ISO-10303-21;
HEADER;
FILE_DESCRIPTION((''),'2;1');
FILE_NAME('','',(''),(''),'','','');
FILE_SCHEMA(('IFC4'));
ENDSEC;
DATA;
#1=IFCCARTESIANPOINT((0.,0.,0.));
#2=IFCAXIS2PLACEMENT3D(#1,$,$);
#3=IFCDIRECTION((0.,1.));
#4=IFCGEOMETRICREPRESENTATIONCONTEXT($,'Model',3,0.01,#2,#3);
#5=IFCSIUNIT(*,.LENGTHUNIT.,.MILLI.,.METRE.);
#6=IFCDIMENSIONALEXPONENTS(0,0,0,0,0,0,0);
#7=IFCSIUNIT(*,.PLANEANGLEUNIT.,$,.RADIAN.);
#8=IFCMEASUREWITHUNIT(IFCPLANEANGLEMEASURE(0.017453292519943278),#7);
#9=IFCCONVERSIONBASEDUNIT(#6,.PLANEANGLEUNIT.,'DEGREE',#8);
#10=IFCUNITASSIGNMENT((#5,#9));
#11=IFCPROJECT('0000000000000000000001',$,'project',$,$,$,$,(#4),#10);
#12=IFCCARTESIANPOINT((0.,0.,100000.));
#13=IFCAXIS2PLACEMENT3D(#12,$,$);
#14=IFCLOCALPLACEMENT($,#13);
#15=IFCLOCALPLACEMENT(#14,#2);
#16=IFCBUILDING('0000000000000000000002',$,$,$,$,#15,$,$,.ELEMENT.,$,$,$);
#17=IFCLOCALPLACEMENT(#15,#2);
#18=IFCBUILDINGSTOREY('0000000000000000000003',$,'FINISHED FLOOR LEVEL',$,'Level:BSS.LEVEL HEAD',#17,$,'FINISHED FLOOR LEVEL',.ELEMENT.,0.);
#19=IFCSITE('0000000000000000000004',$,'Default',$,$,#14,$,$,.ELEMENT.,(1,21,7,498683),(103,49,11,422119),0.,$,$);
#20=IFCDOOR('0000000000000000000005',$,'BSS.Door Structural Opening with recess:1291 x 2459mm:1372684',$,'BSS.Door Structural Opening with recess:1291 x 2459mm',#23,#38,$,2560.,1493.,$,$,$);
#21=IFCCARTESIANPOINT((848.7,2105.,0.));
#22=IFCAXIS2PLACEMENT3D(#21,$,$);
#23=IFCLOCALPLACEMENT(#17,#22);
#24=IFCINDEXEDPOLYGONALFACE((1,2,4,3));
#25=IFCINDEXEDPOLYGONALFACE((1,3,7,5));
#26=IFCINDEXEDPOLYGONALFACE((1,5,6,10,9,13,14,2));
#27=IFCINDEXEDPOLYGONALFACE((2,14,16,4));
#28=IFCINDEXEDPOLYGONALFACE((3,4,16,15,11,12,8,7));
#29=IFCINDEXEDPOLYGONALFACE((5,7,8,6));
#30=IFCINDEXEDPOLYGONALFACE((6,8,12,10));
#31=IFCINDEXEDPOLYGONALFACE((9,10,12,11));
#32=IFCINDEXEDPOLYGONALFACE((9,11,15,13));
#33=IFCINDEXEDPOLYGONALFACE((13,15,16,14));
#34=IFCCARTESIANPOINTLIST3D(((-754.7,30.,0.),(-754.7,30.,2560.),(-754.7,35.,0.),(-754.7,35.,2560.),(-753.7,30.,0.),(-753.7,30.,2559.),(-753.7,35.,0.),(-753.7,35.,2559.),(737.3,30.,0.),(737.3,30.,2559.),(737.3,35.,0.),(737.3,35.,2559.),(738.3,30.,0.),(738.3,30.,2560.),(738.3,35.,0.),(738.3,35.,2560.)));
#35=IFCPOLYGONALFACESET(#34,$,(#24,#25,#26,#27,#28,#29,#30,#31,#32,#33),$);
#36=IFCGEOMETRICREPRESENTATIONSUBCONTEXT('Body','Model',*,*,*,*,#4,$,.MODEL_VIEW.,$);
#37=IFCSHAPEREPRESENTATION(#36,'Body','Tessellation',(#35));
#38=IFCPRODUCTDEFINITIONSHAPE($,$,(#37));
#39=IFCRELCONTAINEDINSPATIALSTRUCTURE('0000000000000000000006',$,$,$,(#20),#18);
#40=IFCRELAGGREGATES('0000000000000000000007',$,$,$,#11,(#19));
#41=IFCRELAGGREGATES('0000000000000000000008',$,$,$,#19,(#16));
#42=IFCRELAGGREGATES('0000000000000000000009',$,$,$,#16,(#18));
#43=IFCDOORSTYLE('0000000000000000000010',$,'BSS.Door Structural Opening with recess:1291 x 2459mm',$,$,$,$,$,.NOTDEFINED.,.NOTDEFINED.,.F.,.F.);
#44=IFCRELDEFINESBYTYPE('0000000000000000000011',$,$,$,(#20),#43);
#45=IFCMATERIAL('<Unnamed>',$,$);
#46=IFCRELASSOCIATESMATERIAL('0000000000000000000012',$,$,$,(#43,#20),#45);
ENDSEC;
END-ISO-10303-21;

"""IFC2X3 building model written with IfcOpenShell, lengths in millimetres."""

from ifc_helpers import new_model, entity, si_unit, converted_unit, direction, frame, origin, place, context, subcontext, project, spatial, polyline, outline, extrude, source, transform, mapped, material, type_object, type_shapes, element, save


model = new_model("IFC2X3")

# Units and contexts
model_context = context("Model", 3, precision=0.01, world=origin(), true_north=direction((0.0, 1.0)))
body_context = subcontext(model_context, "Body", "Model", "MODEL_VIEW")
ifc_project = project(units=[si_unit("LENGTHUNIT", "METRE", prefix="MILLI"), converted_unit("PLANEANGLEUNIT", "DEGREE", entity("IfcPlaneAngleMeasure", 0.017453292519943278), si_unit("PLANEANGLEUNIT", "RADIAN"), dimensions=[0, 0, 0, 0, 0, 0, 0])], contexts=[model_context])

# Site, building, storey
site_placement = place(None, frame((0.0, 0.0, 100000.0)))
site = spatial("IfcSite", under=ifc_project, at=site_placement, Name="Default", CompositionType="ELEMENT", RefLatitude=(1, 21, 7, 498683), RefLongitude=(103, 49, 11, 422119), RefElevation=0.0)
building_placement = place(site_placement, origin())
building = spatial("IfcBuilding", under=site, at=building_placement, CompositionType="ELEMENT")
storey_placement = place(building_placement, origin())
storey = spatial("IfcBuildingStorey", under=building, at=storey_placement, Name="FINISHED FLOOR LEVEL", ObjectType="Level:BSS.LEVEL HEAD", LongName="FINISHED FLOOR LEVEL", CompositionType="ELEMENT", Elevation=0.0)

# Door
ifc_material_1 = material(Name="<Unnamed>")
door_style = type_object("IfcDoorStyle", Name="BSS.Door Structural Opening with recess:1291 x 2459mm", ConstructionType="NOTDEFINED", OperationType="NOTDEFINED", ParameterTakesPrecedence=False, Sizeable=False, material=ifc_material_1)
shared_shape_1 = source(origin(), body_context, "Body", "SweptSolid", [
    extrude(outline(polyline([(-746.5, -1279.7), (-745.5, -1279.7), (-745.5, 1279.2), (745.5, 1279.2), (745.5, -1279.7), (746.5, -1279.7), (746.5, 1280.2), (-746.5, 1280.2), (-746.5, -1279.7)])), frame((-8.2, 30.0, 1279.7), z_axis=(0.0, 1.0, 0.0), x_axis=(-1.0, 0.0, 0.0)), (0.0, 0.0, 1.0), 5.0),
])
type_shapes(door_style, [shared_shape_1])
door_placement = place(storey_placement, frame((848.7, 2105.0, 0.0)))
element("IfcDoor", 1, at=door_placement, inside=storey, type_object=door_style, material=ifc_material_1, Name="BSS.Door Structural Opening with recess:1291 x 2459mm:1372684", ObjectType="BSS.Door Structural Opening with recess:1291 x 2459mm", OverallHeight=2560.0, OverallWidth=1493.0, context=body_context, shape_type="MappedRepresentation", body=[
    mapped(shared_shape_1, transform((0.0, 0.0, 0.0), scale=1.0)),
])

save(model, "model.ifc")
